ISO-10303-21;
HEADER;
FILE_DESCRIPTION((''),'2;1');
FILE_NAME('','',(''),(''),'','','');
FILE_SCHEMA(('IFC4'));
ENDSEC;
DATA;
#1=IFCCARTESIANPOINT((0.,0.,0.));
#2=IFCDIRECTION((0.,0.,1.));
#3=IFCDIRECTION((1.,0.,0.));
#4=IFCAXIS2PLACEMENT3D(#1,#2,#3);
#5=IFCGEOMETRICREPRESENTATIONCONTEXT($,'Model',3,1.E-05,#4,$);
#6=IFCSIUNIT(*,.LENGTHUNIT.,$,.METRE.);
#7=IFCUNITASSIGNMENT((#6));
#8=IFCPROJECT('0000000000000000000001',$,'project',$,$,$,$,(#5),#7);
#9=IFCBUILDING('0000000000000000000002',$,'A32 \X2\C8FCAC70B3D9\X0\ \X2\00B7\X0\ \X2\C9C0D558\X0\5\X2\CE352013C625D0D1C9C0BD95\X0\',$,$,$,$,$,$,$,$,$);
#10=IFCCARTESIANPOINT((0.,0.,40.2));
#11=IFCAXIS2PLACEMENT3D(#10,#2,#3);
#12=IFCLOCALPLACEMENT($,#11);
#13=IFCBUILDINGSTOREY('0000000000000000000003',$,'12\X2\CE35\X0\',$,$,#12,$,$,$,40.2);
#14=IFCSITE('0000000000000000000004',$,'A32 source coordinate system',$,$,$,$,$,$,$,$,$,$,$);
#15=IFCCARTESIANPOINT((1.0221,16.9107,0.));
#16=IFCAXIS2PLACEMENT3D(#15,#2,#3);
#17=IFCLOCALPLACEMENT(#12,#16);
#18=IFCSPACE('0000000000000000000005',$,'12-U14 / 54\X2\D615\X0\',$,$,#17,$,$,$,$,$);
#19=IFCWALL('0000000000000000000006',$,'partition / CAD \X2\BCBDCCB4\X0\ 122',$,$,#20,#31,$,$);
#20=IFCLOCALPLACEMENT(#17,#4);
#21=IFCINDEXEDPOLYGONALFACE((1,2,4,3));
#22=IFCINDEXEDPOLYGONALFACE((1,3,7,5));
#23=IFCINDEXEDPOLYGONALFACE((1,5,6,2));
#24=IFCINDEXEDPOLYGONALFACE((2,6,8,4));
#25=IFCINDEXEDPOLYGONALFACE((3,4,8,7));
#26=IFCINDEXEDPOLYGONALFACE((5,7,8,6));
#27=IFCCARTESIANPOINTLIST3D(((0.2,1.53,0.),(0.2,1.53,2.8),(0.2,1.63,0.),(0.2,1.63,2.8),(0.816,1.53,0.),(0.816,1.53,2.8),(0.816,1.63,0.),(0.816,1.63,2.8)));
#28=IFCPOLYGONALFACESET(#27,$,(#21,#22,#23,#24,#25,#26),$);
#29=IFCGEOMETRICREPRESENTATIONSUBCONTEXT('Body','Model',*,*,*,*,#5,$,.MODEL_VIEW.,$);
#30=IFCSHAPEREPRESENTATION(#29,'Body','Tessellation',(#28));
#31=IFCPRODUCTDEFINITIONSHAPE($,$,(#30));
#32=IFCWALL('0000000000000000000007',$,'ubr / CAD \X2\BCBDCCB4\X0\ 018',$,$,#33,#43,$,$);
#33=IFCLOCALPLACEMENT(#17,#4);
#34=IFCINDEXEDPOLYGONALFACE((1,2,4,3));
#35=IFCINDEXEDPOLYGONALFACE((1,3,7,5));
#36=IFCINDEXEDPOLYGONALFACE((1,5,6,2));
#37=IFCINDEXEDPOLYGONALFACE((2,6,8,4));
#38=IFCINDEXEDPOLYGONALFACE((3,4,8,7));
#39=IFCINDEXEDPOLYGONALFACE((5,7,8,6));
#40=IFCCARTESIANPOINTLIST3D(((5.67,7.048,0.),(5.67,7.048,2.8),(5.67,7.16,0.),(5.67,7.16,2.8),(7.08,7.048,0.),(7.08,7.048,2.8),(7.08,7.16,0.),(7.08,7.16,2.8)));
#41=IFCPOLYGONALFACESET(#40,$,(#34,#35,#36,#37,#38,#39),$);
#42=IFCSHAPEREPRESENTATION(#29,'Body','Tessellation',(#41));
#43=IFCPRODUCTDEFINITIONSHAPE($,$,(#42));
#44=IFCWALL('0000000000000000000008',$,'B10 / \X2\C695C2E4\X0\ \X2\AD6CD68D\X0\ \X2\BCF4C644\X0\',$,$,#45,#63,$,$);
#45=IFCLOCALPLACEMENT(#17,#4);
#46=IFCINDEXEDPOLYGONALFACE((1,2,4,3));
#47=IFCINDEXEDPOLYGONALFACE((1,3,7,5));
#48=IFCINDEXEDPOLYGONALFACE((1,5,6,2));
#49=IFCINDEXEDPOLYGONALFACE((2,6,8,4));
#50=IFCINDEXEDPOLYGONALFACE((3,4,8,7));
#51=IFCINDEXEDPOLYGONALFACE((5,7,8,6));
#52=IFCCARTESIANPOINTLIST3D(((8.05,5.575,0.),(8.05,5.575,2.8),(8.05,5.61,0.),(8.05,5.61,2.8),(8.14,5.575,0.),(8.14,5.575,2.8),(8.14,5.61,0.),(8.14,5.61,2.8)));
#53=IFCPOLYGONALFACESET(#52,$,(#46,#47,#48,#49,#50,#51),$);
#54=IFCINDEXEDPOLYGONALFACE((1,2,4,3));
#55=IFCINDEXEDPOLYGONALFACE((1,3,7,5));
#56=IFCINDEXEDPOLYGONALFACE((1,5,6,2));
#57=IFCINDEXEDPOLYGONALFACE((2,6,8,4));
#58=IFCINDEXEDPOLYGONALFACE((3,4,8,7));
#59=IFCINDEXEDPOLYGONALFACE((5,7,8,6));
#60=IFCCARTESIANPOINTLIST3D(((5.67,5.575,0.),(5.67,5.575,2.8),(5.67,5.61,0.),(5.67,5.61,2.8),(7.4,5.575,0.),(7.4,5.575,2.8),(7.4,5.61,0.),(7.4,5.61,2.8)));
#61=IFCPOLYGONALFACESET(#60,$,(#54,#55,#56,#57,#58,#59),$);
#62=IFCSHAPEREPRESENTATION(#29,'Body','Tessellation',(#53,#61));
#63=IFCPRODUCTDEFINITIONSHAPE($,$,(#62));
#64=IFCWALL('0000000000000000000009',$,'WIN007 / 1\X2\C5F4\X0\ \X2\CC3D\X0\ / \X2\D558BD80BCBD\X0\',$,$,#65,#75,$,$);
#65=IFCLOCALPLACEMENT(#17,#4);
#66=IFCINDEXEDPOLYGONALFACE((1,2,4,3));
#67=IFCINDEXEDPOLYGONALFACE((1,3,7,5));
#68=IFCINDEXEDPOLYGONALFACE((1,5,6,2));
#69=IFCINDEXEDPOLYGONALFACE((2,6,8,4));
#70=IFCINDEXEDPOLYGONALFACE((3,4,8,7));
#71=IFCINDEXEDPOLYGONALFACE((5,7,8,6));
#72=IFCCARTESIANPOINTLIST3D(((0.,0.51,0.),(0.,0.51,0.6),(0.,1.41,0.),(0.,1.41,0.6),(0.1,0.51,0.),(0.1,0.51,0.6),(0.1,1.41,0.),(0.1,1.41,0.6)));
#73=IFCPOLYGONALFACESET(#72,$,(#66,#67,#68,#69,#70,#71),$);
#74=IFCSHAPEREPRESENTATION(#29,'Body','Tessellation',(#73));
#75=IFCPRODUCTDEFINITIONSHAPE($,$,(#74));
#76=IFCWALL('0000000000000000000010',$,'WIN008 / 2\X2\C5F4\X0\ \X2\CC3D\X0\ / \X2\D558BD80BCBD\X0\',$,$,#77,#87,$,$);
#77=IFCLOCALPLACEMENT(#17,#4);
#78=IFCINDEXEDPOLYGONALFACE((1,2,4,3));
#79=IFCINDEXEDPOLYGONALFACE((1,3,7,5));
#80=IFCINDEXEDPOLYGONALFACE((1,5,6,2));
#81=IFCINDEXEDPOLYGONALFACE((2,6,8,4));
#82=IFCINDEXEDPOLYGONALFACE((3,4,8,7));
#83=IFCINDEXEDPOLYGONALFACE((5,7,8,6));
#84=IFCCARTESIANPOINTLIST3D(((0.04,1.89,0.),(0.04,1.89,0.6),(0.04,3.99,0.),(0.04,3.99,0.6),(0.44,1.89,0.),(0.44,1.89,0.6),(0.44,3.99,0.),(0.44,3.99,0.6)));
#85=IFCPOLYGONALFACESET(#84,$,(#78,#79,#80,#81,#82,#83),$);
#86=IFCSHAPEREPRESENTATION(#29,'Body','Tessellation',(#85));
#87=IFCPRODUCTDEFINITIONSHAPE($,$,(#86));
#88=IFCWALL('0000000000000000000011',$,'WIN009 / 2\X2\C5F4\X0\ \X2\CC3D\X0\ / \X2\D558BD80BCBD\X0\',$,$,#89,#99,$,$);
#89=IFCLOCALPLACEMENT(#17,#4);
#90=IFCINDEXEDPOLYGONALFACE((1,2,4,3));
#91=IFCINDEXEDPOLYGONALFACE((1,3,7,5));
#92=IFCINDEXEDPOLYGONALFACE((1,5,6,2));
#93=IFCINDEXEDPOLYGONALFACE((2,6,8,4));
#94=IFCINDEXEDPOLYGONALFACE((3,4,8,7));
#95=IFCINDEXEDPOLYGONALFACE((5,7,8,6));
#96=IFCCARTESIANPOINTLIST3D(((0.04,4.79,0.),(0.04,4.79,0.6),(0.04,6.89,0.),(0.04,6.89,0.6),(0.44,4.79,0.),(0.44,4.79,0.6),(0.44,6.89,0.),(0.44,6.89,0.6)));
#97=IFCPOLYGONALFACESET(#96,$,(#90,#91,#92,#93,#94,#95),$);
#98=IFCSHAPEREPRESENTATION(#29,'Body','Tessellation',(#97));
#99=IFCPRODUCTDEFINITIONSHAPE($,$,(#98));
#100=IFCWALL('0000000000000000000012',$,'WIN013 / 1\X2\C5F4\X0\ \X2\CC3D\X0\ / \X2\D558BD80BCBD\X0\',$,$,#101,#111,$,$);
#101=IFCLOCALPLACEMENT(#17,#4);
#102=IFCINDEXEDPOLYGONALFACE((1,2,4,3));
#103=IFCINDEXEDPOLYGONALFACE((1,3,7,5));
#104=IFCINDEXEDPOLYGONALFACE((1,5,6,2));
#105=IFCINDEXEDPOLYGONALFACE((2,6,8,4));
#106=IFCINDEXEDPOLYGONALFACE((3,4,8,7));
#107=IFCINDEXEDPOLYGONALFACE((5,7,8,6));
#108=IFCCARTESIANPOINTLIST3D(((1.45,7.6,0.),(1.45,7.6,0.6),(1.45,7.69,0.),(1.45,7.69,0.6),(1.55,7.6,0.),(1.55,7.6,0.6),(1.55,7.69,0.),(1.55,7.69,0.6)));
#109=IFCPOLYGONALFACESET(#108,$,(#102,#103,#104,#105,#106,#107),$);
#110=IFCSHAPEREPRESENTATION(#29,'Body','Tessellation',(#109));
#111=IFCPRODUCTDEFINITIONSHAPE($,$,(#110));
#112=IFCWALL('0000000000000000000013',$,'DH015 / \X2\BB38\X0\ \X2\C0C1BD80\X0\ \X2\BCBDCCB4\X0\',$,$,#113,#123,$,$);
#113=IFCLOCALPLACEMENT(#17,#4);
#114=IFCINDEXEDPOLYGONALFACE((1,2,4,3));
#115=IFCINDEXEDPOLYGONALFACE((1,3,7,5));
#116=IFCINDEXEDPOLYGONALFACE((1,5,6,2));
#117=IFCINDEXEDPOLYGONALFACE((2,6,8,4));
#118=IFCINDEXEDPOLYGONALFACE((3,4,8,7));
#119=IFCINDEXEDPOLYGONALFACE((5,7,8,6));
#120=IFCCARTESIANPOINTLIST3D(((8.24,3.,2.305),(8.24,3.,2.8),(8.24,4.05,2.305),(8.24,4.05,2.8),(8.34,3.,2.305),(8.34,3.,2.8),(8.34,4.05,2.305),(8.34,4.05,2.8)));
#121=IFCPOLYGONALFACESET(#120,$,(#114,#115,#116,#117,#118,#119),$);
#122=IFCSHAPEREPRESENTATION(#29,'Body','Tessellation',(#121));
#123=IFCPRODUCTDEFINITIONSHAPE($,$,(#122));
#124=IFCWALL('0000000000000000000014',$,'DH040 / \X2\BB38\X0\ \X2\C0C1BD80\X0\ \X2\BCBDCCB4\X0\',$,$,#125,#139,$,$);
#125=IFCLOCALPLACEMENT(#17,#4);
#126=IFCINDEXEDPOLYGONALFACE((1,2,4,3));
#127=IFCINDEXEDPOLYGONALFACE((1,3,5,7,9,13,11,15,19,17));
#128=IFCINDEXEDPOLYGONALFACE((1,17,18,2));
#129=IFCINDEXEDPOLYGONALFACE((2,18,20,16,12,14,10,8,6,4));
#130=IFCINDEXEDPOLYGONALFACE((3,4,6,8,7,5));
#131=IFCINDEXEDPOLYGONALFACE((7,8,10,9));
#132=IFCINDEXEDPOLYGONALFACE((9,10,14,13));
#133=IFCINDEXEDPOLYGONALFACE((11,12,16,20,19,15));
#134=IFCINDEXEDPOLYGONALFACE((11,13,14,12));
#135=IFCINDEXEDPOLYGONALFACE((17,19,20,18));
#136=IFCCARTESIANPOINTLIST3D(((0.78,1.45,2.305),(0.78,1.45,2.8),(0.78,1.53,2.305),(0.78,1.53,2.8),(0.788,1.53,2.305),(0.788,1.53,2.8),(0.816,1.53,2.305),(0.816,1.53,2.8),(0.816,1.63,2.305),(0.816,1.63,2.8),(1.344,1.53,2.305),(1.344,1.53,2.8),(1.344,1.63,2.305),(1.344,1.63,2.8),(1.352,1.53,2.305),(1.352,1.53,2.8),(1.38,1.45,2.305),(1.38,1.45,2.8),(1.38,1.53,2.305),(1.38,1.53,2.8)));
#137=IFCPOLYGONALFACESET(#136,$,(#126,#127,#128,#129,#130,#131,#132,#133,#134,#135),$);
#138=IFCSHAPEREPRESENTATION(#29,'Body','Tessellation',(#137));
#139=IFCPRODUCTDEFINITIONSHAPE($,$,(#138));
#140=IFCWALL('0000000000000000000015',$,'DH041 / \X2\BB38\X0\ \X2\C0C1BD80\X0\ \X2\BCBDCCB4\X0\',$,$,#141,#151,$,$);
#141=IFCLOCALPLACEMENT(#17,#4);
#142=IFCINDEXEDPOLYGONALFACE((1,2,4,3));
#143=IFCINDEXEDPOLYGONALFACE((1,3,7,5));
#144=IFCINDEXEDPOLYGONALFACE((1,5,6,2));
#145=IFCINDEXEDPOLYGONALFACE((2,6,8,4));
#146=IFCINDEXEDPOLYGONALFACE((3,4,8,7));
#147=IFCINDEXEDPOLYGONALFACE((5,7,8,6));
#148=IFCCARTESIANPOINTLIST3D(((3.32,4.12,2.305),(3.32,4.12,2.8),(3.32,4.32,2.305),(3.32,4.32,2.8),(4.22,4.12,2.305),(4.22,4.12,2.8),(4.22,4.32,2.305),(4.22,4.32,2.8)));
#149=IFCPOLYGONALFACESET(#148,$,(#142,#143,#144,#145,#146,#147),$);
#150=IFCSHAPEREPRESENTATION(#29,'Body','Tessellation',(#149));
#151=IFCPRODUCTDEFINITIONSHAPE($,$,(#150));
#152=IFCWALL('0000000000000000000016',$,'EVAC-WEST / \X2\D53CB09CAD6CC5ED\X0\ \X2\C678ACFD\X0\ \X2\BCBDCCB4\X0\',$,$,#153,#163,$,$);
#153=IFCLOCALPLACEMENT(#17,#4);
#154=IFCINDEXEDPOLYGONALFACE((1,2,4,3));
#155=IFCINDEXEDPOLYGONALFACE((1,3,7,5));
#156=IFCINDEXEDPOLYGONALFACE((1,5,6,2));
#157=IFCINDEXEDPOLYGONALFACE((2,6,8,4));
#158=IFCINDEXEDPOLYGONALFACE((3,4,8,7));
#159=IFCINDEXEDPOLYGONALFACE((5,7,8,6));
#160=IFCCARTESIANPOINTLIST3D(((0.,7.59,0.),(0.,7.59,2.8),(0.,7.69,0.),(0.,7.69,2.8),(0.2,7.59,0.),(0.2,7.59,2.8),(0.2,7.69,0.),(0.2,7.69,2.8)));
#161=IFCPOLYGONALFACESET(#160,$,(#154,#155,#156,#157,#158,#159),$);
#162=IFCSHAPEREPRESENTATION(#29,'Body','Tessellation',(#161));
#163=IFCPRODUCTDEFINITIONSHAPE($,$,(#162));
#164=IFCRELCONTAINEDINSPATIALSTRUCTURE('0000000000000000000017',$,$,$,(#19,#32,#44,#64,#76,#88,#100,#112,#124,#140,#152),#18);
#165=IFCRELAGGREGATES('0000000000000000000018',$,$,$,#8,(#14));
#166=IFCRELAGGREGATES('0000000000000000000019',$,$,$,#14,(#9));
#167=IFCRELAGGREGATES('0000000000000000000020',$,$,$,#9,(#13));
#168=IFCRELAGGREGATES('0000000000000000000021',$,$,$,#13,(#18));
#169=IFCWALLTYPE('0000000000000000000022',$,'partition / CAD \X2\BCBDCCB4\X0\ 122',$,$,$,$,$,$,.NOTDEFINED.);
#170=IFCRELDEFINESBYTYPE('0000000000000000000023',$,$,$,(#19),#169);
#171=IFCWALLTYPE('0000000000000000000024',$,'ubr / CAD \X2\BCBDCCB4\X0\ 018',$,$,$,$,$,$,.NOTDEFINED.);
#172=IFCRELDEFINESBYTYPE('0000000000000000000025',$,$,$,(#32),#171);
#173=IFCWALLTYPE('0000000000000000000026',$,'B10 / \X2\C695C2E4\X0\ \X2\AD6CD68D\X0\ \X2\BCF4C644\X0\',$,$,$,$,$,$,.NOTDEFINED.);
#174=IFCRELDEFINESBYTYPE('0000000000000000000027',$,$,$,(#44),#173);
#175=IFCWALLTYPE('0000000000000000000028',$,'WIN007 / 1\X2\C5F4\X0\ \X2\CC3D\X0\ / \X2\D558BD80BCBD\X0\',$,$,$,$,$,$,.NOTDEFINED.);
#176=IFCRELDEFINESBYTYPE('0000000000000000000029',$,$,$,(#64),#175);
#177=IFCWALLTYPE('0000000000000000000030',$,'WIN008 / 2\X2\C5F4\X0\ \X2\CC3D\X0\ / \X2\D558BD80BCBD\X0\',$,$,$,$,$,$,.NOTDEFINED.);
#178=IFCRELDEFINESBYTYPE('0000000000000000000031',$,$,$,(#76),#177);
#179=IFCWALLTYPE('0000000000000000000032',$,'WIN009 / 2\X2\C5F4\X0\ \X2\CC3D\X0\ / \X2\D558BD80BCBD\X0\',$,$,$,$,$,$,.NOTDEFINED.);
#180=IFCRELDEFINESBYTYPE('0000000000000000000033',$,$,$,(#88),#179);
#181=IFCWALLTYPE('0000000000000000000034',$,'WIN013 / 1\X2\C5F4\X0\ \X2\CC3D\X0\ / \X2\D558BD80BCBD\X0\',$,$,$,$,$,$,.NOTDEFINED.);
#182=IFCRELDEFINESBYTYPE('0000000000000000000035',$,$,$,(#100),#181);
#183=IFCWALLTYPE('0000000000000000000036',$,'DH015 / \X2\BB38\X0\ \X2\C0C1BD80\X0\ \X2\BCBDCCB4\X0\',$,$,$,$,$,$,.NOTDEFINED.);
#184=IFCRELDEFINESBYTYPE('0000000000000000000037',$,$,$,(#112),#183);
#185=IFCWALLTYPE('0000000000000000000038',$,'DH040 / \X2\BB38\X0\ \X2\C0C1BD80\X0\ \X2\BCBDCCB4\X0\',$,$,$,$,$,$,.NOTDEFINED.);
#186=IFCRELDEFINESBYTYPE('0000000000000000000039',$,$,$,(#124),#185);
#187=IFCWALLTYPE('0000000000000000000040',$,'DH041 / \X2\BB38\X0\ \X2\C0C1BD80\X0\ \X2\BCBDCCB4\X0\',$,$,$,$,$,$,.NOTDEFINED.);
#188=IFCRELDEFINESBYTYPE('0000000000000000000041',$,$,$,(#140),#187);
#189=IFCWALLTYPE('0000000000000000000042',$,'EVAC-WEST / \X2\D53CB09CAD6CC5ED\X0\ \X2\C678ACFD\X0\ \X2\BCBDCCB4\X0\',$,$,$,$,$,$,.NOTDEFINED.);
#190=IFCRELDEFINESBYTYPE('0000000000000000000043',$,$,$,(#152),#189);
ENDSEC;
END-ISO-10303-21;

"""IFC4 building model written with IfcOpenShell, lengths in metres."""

from ifc_helpers import new_model, si_unit, frame, origin, origin_with_axes, place, context, subcontext, project, spatial, polyline, outline, extrude, source, transform, mapped, type_object, type_shapes, element, save


model = new_model("IFC4")

# Units and contexts
model_context = context("Model", 3, precision=1e-05, world=origin_with_axes())
body_context = subcontext(model_context, "Body", "Model", "MODEL_VIEW")
ifc_project = project(units=[si_unit("LENGTHUNIT", "METRE")], contexts=[model_context])

# Site, building, storey, space
site = spatial("IfcSite", under=ifc_project, Name="A32 source coordinate system")
building = spatial("IfcBuilding", under=site, Name="A32 주거동 · 지하5층–옥탑지붕")
storey_placement = place(None, frame((0.0, 0.0, 40.2), z_axis=(0.0, 0.0, 1.0), x_axis=(1.0, 0.0, 0.0)))
storey = spatial("IfcBuildingStorey", under=building, at=storey_placement, Name="12층", Elevation=40.2)
space_placement = place(storey_placement, frame((1.0221, 16.9107, 0.0), z_axis=(0.0, 0.0, 1.0), x_axis=(1.0, 0.0, 0.0)))
space = spatial("IfcSpace", under=storey, at=space_placement, Name="12-U14 / 54형")

# Walls
wall_type_1 = type_object("IfcWallType", Name="partition / CAD 벽체 122", PredefinedType="NOTDEFINED")
shared_shape_1 = source(origin(), body_context, "Body", "SweptSolid", [
    extrude(outline(polyline([(0.816, 1.63), (0.816, 1.53), (0.2, 1.53), (0.2, 1.63), (0.816, 1.63)])), origin(), (0.0, 0.0, 1.0), 2.8),
])
type_shapes(wall_type_1, [shared_shape_1])
wall_1_placement = place(space_placement, origin_with_axes())
element("IfcWall", 1, at=wall_1_placement, inside=space, type_object=wall_type_1, Name="partition / CAD 벽체 122", context=body_context, shape_type="MappedRepresentation", body=[
    mapped(shared_shape_1, transform((0.0, 0.0, 0.0), scale=1.0)),
])
wall_type_2 = type_object("IfcWallType", Name="ubr / CAD 벽체 018", PredefinedType="NOTDEFINED")
shared_shape_2 = source(origin(), body_context, "Body", "SweptSolid", [
    extrude(outline(polyline([(5.67, 7.16), (7.08, 7.16), (7.08, 7.048), (5.67, 7.048), (5.67, 7.16)])), origin(), (0.0, 0.0, 1.0), 2.8),
])
type_shapes(wall_type_2, [shared_shape_2])
wall_2_placement = place(space_placement, origin_with_axes())
element("IfcWall", 2, at=wall_2_placement, inside=space, type_object=wall_type_2, Name="ubr / CAD 벽체 018", context=body_context, shape_type="MappedRepresentation", body=[
    mapped(shared_shape_2, transform((0.0, 0.0, 0.0), scale=1.0)),
])
wall_type_3 = type_object("IfcWallType", Name="B10 / 욕실 구획 보완", PredefinedType="NOTDEFINED")
shared_shape_3 = source(origin(), body_context, "Body", "SweptSolid", [
    extrude(outline(polyline([(8.14, 5.575), (8.05, 5.575), (8.05, 5.61), (8.14, 5.61), (8.14, 5.575)])), origin(), (0.0, 0.0, 1.0), 2.8),
    extrude(outline(polyline([(7.4, 5.575), (5.67, 5.575), (5.67, 5.61), (7.4, 5.61), (7.4, 5.575)])), origin(), (0.0, 0.0, 1.0), 2.8),
])
type_shapes(wall_type_3, [shared_shape_3])
wall_3_placement = place(space_placement, origin_with_axes())
element("IfcWall", 3, at=wall_3_placement, inside=space, type_object=wall_type_3, Name="B10 / 욕실 구획 보완", context=body_context, shape_type="MappedRepresentation", body=[
    mapped(shared_shape_3, transform((0.0, 0.0, 0.0), scale=1.0)),
])
wall_type_4 = type_object("IfcWallType", Name="WIN007 / 1열 창 / 하부벽", PredefinedType="NOTDEFINED")
shared_shape_4 = source(origin(), body_context, "Body", "SweptSolid", [
    extrude(outline(polyline([(0.1, 1.41), (0.1, 0.51), (0.0, 0.51), (0.0, 1.41), (0.1, 1.41)])), origin(), (0.0, 0.0, 1.0), 0.6),
])
type_shapes(wall_type_4, [shared_shape_4])
wall_4_placement = place(space_placement, origin_with_axes())
element("IfcWall", 4, at=wall_4_placement, inside=space, type_object=wall_type_4, Name="WIN007 / 1열 창 / 하부벽", context=body_context, shape_type="MappedRepresentation", body=[
    mapped(shared_shape_4, transform((0.0, 0.0, 0.0), scale=1.0)),
])
wall_type_5 = type_object("IfcWallType", Name="WIN008 / 2열 창 / 하부벽", PredefinedType="NOTDEFINED")
shared_shape_5 = source(origin(), body_context, "Body", "SweptSolid", [
    extrude(outline(polyline([(0.44, 3.99), (0.44, 1.89), (0.04, 1.89), (0.04, 3.99), (0.44, 3.99)])), origin(), (0.0, 0.0, 1.0), 0.6),
])
type_shapes(wall_type_5, [shared_shape_5])
wall_5_placement = place(space_placement, origin_with_axes())
element("IfcWall", 5, at=wall_5_placement, inside=space, type_object=wall_type_5, Name="WIN008 / 2열 창 / 하부벽", context=body_context, shape_type="MappedRepresentation", body=[
    mapped(shared_shape_5, transform((0.0, 0.0, 0.0), scale=1.0)),
])
wall_type_6 = type_object("IfcWallType", Name="WIN009 / 2열 창 / 하부벽", PredefinedType="NOTDEFINED")
shared_shape_6 = source(origin(), body_context, "Body", "SweptSolid", [
    extrude(outline(polyline([(0.44, 6.89), (0.44, 4.79), (0.04, 4.79), (0.04, 6.89), (0.44, 6.89)])), origin(), (0.0, 0.0, 1.0), 0.6),
])
type_shapes(wall_type_6, [shared_shape_6])
wall_6_placement = place(space_placement, origin_with_axes())
element("IfcWall", 6, at=wall_6_placement, inside=space, type_object=wall_type_6, Name="WIN009 / 2열 창 / 하부벽", context=body_context, shape_type="MappedRepresentation", body=[
    mapped(shared_shape_6, transform((0.0, 0.0, 0.0), scale=1.0)),
])
wall_type_7 = type_object("IfcWallType", Name="WIN013 / 1열 창 / 하부벽", PredefinedType="NOTDEFINED")
shared_shape_7 = source(origin(), body_context, "Body", "SweptSolid", [
    extrude(outline(polyline([(1.55, 7.6), (1.45, 7.6), (1.45, 7.69), (1.55, 7.69), (1.55, 7.6)])), origin(), (0.0, 0.0, 1.0), 0.6),
])
type_shapes(wall_type_7, [shared_shape_7])
wall_7_placement = place(space_placement, origin_with_axes())
element("IfcWall", 7, at=wall_7_placement, inside=space, type_object=wall_type_7, Name="WIN013 / 1열 창 / 하부벽", context=body_context, shape_type="MappedRepresentation", body=[
    mapped(shared_shape_7, transform((0.0, 0.0, 0.0), scale=1.0)),
])
wall_type_8 = type_object("IfcWallType", Name="DH015 / 문 상부 벽체", PredefinedType="NOTDEFINED")
shared_shape_8 = source(origin(), body_context, "Body", "SweptSolid", [
    extrude(outline(polyline([(8.34, 3.0), (8.24, 3.0), (8.24, 4.05), (8.34, 4.05), (8.34, 3.0)])), frame((0.0, 0.0, 2.305)), (0.0, 0.0, 1.0), 0.495),
])
type_shapes(wall_type_8, [shared_shape_8])
wall_8_placement = place(space_placement, origin_with_axes())
element("IfcWall", 8, at=wall_8_placement, inside=space, type_object=wall_type_8, Name="DH015 / 문 상부 벽체", context=body_context, shape_type="MappedRepresentation", body=[
    mapped(shared_shape_8, transform((0.0, 0.0, 0.0), scale=1.0)),
])
wall_type_9 = type_object("IfcWallType", Name="DH040 / 문 상부 벽체", PredefinedType="NOTDEFINED")
shared_shape_9 = source(origin(), body_context, "Body", "SweptSolid", [
    extrude(outline(polyline([(0.816, 1.63), (1.344, 1.63), (1.344, 1.53), (1.352, 1.53), (1.38, 1.53), (1.38, 1.45), (0.78, 1.45), (0.78, 1.53), (0.788, 1.53), (0.816, 1.53), (0.816, 1.63)])), frame((0.0, 0.0, 2.305)), (0.0, 0.0, 1.0), 0.495),
])
type_shapes(wall_type_9, [shared_shape_9])
wall_9_placement = place(space_placement, origin_with_axes())
element("IfcWall", 9, at=wall_9_placement, inside=space, type_object=wall_type_9, Name="DH040 / 문 상부 벽체", context=body_context, shape_type="MappedRepresentation", body=[
    mapped(shared_shape_9, transform((0.0, 0.0, 0.0), scale=1.0)),
])
wall_type_10 = type_object("IfcWallType", Name="DH041 / 문 상부 벽체", PredefinedType="NOTDEFINED")
shared_shape_10 = source(origin(), body_context, "Body", "SweptSolid", [
    extrude(outline(polyline([(4.22, 4.12), (3.32, 4.12), (3.32, 4.32), (4.22, 4.32), (4.22, 4.12)])), frame((0.0, 0.0, 2.305)), (0.0, 0.0, 1.0), 0.495),
])
type_shapes(wall_type_10, [shared_shape_10])
wall_10_placement = place(space_placement, origin_with_axes())
element("IfcWall", 10, at=wall_10_placement, inside=space, type_object=wall_type_10, Name="DH041 / 문 상부 벽체", context=body_context, shape_type="MappedRepresentation", body=[
    mapped(shared_shape_10, transform((0.0, 0.0, 0.0), scale=1.0)),
])
wall_type_11 = type_object("IfcWallType", Name="EVAC-WEST / 피난구역 외곽 벽체", PredefinedType="NOTDEFINED")
shared_shape_11 = source(origin(), body_context, "Body", "SweptSolid", [
    extrude(outline(polyline([(0.2, 7.59), (0.0, 7.59), (0.0, 7.69), (0.2, 7.69), (0.2, 7.59)])), origin(), (0.0, 0.0, 1.0), 2.8),
])
type_shapes(wall_type_11, [shared_shape_11])
wall_11_placement = place(space_placement, origin_with_axes())
element("IfcWall", 11, at=wall_11_placement, inside=space, type_object=wall_type_11, Name="EVAC-WEST / 피난구역 외곽 벽체", context=body_context, shape_type="MappedRepresentation", body=[
    mapped(shared_shape_11, transform((0.0, 0.0, 0.0), scale=1.0)),
])

save(model, "model.ifc")
